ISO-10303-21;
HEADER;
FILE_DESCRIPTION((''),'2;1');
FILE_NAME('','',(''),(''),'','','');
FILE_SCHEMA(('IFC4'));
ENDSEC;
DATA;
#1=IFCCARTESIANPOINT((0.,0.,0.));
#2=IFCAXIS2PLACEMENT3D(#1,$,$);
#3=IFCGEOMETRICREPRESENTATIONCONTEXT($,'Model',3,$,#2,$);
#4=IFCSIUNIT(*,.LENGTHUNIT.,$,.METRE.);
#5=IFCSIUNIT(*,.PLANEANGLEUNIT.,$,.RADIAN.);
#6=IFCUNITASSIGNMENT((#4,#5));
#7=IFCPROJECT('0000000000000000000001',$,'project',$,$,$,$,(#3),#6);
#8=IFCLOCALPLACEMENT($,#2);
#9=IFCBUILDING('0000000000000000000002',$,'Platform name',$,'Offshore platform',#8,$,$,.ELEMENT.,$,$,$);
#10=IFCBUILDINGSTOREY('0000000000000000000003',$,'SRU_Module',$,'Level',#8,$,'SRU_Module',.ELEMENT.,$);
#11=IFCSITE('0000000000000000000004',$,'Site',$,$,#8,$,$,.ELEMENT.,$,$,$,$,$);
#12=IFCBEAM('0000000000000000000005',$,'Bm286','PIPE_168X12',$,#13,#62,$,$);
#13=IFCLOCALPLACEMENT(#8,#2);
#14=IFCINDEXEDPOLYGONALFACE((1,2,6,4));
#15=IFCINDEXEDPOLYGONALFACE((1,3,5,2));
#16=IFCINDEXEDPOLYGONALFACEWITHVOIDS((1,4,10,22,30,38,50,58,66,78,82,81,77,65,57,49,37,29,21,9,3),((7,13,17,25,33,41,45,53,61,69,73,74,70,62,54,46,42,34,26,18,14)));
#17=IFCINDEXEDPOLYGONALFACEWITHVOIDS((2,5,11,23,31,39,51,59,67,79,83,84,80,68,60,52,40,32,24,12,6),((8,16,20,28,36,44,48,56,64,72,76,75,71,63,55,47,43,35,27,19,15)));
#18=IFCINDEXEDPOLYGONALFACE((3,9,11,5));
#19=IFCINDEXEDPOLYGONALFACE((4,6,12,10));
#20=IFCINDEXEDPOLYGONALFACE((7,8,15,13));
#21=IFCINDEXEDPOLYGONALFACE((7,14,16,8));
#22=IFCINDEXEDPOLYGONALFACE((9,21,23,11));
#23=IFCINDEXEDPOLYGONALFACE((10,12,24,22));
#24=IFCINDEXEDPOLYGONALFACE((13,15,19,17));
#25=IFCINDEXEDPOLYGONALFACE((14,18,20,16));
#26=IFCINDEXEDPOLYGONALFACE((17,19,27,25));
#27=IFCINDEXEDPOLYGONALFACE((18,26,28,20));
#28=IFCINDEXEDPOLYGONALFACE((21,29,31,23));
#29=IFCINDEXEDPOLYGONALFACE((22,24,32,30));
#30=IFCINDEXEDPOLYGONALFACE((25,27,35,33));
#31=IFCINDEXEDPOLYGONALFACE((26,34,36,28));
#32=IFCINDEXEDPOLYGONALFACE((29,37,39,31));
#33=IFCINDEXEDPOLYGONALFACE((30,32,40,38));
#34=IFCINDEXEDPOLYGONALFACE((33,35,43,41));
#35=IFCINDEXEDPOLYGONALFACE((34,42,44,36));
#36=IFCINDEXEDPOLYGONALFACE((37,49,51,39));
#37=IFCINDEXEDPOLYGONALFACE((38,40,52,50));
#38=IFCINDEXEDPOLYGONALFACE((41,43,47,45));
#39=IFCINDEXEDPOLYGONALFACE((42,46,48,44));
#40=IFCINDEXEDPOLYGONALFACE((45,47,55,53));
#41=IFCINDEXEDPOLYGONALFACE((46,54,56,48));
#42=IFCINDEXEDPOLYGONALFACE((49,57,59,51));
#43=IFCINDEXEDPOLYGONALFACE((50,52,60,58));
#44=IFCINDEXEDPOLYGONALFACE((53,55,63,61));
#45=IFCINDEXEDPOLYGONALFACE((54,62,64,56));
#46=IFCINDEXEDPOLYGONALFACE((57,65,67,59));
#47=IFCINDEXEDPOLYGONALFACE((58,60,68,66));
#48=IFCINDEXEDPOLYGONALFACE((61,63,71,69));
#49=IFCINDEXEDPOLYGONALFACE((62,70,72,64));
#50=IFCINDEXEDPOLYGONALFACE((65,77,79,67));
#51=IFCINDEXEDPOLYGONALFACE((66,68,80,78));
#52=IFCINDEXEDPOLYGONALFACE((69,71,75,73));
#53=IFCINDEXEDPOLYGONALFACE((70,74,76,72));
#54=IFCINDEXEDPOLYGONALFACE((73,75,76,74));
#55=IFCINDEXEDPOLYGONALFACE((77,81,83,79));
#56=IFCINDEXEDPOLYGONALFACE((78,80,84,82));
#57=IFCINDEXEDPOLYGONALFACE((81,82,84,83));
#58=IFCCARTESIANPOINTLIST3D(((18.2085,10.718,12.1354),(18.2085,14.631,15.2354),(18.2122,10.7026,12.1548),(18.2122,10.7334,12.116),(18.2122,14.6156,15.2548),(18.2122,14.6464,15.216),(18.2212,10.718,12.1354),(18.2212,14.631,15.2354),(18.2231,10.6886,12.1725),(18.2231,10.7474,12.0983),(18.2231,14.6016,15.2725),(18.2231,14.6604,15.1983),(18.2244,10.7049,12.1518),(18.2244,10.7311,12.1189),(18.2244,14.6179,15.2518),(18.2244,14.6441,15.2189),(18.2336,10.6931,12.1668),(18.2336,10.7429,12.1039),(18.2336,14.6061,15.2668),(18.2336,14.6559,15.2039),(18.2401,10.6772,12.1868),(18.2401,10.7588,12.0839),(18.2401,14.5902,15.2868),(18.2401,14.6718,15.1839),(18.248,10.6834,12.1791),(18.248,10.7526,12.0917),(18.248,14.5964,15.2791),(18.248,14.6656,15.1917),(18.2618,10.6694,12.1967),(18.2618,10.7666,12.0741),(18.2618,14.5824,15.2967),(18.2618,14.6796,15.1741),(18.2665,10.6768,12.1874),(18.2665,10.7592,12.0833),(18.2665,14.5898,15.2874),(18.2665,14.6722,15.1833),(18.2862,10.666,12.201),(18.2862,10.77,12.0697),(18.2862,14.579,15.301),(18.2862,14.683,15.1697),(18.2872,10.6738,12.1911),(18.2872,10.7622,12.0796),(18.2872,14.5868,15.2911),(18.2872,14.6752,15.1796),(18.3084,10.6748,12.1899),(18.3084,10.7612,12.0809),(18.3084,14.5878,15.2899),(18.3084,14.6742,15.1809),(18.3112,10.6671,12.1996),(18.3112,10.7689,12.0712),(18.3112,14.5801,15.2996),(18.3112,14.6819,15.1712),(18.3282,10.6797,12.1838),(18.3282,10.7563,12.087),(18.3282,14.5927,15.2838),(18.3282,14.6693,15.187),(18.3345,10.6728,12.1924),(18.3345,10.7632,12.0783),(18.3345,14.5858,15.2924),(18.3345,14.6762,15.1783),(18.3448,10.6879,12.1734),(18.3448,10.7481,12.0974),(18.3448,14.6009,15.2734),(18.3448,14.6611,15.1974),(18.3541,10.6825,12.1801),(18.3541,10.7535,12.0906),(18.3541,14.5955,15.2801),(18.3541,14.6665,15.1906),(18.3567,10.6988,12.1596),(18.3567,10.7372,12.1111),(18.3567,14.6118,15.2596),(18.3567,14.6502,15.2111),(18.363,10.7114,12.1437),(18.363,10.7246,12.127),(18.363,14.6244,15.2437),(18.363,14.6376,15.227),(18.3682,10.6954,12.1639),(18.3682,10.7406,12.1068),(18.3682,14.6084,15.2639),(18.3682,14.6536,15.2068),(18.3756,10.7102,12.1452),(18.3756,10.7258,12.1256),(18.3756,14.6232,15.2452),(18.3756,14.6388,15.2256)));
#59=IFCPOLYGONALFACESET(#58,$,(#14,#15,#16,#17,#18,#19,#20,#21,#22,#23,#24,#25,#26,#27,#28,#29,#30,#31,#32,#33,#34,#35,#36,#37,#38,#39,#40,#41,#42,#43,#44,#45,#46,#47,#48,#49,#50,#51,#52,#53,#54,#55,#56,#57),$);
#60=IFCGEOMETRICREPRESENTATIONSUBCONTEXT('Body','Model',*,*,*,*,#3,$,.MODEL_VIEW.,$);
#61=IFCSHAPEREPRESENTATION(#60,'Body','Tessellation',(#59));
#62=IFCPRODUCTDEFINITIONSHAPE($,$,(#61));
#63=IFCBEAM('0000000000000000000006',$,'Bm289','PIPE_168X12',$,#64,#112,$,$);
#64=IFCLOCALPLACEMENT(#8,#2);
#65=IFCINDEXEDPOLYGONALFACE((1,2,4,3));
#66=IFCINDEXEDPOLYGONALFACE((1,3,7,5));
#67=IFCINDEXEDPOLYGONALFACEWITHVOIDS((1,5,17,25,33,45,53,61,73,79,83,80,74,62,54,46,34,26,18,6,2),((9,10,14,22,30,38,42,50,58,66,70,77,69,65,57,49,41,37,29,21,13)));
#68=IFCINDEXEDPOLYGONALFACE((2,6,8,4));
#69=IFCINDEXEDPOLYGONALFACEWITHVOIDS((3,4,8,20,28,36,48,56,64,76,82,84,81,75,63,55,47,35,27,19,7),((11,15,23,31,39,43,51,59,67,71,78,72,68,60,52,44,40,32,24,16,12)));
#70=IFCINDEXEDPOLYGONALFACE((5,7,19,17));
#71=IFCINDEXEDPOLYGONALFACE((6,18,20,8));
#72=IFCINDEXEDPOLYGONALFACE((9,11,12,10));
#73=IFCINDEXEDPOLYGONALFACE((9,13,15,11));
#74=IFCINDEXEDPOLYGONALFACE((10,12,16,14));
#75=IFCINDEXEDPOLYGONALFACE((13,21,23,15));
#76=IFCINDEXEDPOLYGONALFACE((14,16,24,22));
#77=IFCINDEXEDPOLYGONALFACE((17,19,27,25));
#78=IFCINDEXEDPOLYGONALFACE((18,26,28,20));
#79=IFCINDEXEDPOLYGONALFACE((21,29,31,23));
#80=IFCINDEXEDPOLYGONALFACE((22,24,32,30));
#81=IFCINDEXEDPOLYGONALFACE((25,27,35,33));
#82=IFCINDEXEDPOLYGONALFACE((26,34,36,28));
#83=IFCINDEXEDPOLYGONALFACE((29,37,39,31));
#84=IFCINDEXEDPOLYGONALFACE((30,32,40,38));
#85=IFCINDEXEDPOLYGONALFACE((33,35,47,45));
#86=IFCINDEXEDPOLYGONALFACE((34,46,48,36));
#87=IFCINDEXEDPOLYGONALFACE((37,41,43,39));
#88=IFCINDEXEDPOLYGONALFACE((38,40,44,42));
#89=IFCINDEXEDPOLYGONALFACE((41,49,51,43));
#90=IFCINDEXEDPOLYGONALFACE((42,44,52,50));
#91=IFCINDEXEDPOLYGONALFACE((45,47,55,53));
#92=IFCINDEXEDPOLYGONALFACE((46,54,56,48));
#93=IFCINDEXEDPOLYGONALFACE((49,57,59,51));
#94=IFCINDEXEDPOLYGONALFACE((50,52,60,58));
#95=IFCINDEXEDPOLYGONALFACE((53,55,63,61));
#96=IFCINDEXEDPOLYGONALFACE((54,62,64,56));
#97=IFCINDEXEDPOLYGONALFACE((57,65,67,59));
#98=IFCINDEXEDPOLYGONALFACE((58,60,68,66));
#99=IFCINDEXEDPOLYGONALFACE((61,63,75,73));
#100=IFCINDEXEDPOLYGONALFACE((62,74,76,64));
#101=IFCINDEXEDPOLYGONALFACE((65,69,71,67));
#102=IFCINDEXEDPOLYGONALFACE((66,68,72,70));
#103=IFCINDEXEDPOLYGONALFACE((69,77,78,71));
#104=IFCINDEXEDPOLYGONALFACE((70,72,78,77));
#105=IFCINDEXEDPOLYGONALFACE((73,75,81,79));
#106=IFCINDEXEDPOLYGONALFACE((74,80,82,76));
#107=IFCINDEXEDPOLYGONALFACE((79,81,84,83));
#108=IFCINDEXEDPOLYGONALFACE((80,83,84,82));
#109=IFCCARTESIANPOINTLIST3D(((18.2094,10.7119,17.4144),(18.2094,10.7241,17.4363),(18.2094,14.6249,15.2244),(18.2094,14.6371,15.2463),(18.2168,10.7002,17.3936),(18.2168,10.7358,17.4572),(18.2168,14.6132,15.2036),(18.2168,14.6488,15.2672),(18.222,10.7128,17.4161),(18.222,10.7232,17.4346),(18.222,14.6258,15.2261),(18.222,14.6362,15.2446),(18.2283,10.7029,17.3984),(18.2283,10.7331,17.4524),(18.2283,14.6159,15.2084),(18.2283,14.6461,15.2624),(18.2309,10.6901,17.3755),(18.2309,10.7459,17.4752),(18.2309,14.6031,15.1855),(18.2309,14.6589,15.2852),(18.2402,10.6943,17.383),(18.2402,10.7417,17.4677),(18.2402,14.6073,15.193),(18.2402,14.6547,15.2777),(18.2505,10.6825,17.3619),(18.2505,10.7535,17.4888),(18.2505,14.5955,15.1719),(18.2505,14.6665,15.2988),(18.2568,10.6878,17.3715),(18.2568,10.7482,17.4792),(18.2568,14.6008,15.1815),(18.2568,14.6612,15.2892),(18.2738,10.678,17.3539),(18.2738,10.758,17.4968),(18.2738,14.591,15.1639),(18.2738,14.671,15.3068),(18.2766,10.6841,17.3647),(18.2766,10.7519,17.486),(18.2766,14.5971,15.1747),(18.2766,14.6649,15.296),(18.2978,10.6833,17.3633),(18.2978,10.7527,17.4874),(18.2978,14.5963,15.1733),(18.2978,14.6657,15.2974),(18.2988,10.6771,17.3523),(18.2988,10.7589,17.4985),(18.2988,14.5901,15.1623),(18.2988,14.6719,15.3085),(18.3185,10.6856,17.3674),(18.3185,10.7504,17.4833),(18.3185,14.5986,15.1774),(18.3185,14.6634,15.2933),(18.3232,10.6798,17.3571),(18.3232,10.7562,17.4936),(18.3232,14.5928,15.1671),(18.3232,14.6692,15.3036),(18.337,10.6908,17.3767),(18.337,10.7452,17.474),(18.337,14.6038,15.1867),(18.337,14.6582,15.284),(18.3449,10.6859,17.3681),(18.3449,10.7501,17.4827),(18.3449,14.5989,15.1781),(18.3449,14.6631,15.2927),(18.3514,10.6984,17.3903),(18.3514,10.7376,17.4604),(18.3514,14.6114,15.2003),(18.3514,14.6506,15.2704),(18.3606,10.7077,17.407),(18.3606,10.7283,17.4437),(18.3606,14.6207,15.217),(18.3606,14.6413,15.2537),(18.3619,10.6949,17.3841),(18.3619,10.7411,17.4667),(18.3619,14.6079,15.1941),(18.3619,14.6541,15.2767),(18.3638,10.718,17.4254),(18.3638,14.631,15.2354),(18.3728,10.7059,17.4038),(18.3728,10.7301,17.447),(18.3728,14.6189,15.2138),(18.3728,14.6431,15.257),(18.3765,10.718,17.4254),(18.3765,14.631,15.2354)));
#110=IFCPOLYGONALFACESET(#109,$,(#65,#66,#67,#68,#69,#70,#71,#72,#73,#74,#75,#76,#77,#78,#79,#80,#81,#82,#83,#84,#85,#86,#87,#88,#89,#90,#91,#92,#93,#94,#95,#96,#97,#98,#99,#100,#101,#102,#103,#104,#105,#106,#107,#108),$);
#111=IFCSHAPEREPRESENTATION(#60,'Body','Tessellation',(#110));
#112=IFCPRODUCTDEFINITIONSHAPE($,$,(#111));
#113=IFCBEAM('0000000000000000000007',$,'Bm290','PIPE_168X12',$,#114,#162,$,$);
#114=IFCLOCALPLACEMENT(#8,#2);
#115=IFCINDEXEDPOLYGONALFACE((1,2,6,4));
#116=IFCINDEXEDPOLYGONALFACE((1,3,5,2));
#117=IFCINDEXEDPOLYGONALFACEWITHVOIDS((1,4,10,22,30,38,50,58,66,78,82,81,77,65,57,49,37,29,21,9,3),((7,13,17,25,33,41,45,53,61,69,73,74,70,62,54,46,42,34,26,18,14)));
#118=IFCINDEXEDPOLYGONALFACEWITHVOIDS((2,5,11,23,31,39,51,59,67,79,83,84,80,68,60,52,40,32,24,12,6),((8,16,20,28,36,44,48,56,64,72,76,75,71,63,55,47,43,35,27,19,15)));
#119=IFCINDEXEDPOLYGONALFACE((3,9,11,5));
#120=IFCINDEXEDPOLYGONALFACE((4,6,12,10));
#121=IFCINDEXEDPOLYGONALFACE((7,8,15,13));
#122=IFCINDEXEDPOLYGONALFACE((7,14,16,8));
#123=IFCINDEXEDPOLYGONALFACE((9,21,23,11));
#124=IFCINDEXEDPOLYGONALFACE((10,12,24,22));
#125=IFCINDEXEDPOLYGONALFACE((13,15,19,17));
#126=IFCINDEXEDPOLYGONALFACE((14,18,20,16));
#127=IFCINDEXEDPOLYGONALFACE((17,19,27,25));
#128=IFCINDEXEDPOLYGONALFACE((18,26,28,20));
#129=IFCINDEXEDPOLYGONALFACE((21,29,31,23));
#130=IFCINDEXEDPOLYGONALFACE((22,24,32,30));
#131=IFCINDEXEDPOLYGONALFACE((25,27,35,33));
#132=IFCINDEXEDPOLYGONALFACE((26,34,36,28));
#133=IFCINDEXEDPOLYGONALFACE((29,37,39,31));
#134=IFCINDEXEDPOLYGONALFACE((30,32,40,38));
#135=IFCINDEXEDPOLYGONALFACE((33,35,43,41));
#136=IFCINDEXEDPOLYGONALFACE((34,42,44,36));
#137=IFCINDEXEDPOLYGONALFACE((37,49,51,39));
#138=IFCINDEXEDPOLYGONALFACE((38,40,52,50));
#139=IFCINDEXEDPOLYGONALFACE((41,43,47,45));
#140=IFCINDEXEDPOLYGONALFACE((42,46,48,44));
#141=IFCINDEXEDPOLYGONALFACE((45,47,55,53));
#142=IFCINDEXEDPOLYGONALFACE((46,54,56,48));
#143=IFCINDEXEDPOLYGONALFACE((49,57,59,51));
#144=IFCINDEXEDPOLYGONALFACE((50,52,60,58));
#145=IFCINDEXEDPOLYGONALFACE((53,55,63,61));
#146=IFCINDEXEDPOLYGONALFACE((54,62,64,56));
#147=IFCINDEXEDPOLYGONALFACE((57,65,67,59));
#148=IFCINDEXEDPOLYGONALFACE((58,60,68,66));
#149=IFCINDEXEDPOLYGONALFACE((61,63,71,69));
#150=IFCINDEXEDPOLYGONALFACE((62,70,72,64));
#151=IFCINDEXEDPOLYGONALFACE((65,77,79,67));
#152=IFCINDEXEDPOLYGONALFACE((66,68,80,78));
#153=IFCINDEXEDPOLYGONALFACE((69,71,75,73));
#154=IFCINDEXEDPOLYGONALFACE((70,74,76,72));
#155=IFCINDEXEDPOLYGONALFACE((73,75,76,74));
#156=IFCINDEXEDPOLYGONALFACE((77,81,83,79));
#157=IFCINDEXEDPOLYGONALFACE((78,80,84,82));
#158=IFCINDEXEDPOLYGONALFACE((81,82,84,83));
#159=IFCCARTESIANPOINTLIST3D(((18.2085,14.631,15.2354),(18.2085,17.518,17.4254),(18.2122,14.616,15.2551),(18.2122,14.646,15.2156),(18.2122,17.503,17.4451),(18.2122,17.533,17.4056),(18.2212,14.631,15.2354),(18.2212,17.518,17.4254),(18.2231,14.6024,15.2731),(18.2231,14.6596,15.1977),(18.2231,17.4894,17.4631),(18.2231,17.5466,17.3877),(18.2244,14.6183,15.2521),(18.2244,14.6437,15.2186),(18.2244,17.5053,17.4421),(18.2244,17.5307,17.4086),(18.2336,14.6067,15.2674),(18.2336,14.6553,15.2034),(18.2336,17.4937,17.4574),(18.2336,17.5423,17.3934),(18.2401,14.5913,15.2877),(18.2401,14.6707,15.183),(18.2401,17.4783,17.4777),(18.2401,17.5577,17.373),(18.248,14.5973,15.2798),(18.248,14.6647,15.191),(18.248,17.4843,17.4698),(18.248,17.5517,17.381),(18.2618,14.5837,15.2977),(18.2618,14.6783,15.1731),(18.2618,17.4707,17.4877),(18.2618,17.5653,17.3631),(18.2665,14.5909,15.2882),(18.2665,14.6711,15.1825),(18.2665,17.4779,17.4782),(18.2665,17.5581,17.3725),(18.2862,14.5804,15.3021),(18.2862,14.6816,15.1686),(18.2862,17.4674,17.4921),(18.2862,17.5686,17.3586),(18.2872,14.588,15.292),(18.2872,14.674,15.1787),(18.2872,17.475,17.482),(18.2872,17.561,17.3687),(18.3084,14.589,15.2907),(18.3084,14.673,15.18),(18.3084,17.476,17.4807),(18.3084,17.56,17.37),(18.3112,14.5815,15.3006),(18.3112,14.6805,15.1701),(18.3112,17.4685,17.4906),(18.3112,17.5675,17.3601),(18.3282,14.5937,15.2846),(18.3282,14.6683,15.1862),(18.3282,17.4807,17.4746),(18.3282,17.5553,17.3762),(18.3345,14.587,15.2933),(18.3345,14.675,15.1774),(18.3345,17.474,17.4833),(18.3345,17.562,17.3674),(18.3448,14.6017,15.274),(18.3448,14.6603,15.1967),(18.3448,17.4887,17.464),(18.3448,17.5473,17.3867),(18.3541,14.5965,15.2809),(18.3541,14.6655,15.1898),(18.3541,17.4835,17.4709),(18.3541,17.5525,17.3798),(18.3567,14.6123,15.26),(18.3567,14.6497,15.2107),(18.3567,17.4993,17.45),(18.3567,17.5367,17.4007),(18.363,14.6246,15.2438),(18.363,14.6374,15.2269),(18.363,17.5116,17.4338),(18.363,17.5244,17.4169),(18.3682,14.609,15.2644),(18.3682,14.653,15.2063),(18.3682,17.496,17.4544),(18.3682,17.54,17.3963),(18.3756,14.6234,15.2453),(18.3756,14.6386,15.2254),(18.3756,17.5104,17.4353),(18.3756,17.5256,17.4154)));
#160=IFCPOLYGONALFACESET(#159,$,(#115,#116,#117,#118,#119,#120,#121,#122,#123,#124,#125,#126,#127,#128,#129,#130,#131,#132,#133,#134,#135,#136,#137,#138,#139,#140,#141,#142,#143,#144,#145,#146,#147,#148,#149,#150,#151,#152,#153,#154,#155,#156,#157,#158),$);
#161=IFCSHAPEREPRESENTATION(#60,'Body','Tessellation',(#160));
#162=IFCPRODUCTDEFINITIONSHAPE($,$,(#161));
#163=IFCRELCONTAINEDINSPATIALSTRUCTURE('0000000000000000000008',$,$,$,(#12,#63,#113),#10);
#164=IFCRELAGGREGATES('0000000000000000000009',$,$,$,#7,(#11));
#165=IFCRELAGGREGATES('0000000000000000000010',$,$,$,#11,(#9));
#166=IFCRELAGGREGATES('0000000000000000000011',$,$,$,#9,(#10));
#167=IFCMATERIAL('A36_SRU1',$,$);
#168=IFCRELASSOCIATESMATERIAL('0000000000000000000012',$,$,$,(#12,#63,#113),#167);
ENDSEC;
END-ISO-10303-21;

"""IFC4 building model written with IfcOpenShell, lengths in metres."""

from ifc_helpers import new_model, si_unit, frame, origin, origin_2d, place, context, subcontext, project, spatial, hollow_circle, extrude, source, transform, mapped, material, element, save


model = new_model("IFC4")

# Units and contexts
model_context = context("Model", 3, world=origin())
body_context = subcontext(model_context, "Body", "Model", "MODEL_VIEW")
ifc_project = project(units=[si_unit("LENGTHUNIT", "METRE"), si_unit("PLANEANGLEUNIT", "RADIAN")], contexts=[model_context])

# Site, building, storey
placement_1 = place(None, origin())
site = spatial("IfcSite", under=ifc_project, at=placement_1, Name="Site", CompositionType="ELEMENT")
building = spatial("IfcBuilding", under=site, at=placement_1, Name="Platform name", ObjectType="Offshore platform", CompositionType="ELEMENT")
storey = spatial("IfcBuildingStorey", under=building, at=placement_1, Name="SRU_Module", ObjectType="Level", LongName="SRU_Module", CompositionType="ELEMENT")

# Beams
ifc_material = material(Name="A36_SRU1")
shared_shape_1 = source(origin(), body_context, "Body", "SweptSolid", [
    extrude(hollow_circle(Radius=0.084, WallThickness=0.0127, at=origin_2d()), frame((0.0, 0.0, 0.0), z_axis=(0.0, 0.78383, 0.620975), x_axis=(-1.0, 0.0, 0.0)), (0.0, 0.0, 1.0), 4.9922),
])
placement_2 = place(None, origin())
placement_3 = place(placement_2, origin())
placement_4 = place(placement_3, origin())
beam_1_placement = place(placement_4, frame((18.2925, 10.718, 12.1354)))
element("IfcBeam", 1, at=beam_1_placement, inside=storey, material=ifc_material, Name="Bm286", Description="PIPE_168X12", context=body_context, shape_type="MappedRepresentation", body=[
    mapped(shared_shape_1, transform((0.0, 0.0, 0.0), scale=1.0)),
])
shared_shape_2 = source(origin(), body_context, "Body", "SweptSolid", [
    extrude(hollow_circle(Radius=0.084, WallThickness=0.0127, at=origin_2d()), frame((0.0, 0.0, 0.0), z_axis=(0.0, -0.872628, 0.488386), x_axis=(1.0, 0.0, 0.0)), (0.0, 0.0, 1.0), 4.4842),
])
placement_5 = place(None, origin())
placement_6 = place(placement_5, origin())
placement_7 = place(placement_6, origin())
beam_2_placement = place(placement_7, frame((18.2925, 14.631, 15.2354)))
element("IfcBeam", 2, at=beam_2_placement, inside=storey, material=ifc_material, Name="Bm289", Description="PIPE_168X12", context=body_context, shape_type="MappedRepresentation", body=[
    mapped(shared_shape_2, transform((0.0, 0.0, 0.0), scale=1.0)),
])
shared_shape_3 = source(origin(), body_context, "Body", "SweptSolid", [
    extrude(hollow_circle(Radius=0.084, WallThickness=0.0127, at=origin_2d()), frame((0.0, 0.0, 0.0), z_axis=(0.0, 0.79671, 0.604362), x_axis=(-1.0, 0.0, 0.0)), (0.0, 0.0, 1.0), 3.6237),
])
placement_8 = place(None, origin())
placement_9 = place(placement_8, origin())
placement_10 = place(placement_9, origin())
beam_3_placement = place(placement_10, frame((18.2925, 14.631, 15.2354)))
element("IfcBeam", 3, at=beam_3_placement, inside=storey, material=ifc_material, Name="Bm290", Description="PIPE_168X12", context=body_context, shape_type="MappedRepresentation", body=[
    mapped(shared_shape_3, transform((0.0, 0.0, 0.0), scale=1.0)),
])

save(model, "model.ifc")
